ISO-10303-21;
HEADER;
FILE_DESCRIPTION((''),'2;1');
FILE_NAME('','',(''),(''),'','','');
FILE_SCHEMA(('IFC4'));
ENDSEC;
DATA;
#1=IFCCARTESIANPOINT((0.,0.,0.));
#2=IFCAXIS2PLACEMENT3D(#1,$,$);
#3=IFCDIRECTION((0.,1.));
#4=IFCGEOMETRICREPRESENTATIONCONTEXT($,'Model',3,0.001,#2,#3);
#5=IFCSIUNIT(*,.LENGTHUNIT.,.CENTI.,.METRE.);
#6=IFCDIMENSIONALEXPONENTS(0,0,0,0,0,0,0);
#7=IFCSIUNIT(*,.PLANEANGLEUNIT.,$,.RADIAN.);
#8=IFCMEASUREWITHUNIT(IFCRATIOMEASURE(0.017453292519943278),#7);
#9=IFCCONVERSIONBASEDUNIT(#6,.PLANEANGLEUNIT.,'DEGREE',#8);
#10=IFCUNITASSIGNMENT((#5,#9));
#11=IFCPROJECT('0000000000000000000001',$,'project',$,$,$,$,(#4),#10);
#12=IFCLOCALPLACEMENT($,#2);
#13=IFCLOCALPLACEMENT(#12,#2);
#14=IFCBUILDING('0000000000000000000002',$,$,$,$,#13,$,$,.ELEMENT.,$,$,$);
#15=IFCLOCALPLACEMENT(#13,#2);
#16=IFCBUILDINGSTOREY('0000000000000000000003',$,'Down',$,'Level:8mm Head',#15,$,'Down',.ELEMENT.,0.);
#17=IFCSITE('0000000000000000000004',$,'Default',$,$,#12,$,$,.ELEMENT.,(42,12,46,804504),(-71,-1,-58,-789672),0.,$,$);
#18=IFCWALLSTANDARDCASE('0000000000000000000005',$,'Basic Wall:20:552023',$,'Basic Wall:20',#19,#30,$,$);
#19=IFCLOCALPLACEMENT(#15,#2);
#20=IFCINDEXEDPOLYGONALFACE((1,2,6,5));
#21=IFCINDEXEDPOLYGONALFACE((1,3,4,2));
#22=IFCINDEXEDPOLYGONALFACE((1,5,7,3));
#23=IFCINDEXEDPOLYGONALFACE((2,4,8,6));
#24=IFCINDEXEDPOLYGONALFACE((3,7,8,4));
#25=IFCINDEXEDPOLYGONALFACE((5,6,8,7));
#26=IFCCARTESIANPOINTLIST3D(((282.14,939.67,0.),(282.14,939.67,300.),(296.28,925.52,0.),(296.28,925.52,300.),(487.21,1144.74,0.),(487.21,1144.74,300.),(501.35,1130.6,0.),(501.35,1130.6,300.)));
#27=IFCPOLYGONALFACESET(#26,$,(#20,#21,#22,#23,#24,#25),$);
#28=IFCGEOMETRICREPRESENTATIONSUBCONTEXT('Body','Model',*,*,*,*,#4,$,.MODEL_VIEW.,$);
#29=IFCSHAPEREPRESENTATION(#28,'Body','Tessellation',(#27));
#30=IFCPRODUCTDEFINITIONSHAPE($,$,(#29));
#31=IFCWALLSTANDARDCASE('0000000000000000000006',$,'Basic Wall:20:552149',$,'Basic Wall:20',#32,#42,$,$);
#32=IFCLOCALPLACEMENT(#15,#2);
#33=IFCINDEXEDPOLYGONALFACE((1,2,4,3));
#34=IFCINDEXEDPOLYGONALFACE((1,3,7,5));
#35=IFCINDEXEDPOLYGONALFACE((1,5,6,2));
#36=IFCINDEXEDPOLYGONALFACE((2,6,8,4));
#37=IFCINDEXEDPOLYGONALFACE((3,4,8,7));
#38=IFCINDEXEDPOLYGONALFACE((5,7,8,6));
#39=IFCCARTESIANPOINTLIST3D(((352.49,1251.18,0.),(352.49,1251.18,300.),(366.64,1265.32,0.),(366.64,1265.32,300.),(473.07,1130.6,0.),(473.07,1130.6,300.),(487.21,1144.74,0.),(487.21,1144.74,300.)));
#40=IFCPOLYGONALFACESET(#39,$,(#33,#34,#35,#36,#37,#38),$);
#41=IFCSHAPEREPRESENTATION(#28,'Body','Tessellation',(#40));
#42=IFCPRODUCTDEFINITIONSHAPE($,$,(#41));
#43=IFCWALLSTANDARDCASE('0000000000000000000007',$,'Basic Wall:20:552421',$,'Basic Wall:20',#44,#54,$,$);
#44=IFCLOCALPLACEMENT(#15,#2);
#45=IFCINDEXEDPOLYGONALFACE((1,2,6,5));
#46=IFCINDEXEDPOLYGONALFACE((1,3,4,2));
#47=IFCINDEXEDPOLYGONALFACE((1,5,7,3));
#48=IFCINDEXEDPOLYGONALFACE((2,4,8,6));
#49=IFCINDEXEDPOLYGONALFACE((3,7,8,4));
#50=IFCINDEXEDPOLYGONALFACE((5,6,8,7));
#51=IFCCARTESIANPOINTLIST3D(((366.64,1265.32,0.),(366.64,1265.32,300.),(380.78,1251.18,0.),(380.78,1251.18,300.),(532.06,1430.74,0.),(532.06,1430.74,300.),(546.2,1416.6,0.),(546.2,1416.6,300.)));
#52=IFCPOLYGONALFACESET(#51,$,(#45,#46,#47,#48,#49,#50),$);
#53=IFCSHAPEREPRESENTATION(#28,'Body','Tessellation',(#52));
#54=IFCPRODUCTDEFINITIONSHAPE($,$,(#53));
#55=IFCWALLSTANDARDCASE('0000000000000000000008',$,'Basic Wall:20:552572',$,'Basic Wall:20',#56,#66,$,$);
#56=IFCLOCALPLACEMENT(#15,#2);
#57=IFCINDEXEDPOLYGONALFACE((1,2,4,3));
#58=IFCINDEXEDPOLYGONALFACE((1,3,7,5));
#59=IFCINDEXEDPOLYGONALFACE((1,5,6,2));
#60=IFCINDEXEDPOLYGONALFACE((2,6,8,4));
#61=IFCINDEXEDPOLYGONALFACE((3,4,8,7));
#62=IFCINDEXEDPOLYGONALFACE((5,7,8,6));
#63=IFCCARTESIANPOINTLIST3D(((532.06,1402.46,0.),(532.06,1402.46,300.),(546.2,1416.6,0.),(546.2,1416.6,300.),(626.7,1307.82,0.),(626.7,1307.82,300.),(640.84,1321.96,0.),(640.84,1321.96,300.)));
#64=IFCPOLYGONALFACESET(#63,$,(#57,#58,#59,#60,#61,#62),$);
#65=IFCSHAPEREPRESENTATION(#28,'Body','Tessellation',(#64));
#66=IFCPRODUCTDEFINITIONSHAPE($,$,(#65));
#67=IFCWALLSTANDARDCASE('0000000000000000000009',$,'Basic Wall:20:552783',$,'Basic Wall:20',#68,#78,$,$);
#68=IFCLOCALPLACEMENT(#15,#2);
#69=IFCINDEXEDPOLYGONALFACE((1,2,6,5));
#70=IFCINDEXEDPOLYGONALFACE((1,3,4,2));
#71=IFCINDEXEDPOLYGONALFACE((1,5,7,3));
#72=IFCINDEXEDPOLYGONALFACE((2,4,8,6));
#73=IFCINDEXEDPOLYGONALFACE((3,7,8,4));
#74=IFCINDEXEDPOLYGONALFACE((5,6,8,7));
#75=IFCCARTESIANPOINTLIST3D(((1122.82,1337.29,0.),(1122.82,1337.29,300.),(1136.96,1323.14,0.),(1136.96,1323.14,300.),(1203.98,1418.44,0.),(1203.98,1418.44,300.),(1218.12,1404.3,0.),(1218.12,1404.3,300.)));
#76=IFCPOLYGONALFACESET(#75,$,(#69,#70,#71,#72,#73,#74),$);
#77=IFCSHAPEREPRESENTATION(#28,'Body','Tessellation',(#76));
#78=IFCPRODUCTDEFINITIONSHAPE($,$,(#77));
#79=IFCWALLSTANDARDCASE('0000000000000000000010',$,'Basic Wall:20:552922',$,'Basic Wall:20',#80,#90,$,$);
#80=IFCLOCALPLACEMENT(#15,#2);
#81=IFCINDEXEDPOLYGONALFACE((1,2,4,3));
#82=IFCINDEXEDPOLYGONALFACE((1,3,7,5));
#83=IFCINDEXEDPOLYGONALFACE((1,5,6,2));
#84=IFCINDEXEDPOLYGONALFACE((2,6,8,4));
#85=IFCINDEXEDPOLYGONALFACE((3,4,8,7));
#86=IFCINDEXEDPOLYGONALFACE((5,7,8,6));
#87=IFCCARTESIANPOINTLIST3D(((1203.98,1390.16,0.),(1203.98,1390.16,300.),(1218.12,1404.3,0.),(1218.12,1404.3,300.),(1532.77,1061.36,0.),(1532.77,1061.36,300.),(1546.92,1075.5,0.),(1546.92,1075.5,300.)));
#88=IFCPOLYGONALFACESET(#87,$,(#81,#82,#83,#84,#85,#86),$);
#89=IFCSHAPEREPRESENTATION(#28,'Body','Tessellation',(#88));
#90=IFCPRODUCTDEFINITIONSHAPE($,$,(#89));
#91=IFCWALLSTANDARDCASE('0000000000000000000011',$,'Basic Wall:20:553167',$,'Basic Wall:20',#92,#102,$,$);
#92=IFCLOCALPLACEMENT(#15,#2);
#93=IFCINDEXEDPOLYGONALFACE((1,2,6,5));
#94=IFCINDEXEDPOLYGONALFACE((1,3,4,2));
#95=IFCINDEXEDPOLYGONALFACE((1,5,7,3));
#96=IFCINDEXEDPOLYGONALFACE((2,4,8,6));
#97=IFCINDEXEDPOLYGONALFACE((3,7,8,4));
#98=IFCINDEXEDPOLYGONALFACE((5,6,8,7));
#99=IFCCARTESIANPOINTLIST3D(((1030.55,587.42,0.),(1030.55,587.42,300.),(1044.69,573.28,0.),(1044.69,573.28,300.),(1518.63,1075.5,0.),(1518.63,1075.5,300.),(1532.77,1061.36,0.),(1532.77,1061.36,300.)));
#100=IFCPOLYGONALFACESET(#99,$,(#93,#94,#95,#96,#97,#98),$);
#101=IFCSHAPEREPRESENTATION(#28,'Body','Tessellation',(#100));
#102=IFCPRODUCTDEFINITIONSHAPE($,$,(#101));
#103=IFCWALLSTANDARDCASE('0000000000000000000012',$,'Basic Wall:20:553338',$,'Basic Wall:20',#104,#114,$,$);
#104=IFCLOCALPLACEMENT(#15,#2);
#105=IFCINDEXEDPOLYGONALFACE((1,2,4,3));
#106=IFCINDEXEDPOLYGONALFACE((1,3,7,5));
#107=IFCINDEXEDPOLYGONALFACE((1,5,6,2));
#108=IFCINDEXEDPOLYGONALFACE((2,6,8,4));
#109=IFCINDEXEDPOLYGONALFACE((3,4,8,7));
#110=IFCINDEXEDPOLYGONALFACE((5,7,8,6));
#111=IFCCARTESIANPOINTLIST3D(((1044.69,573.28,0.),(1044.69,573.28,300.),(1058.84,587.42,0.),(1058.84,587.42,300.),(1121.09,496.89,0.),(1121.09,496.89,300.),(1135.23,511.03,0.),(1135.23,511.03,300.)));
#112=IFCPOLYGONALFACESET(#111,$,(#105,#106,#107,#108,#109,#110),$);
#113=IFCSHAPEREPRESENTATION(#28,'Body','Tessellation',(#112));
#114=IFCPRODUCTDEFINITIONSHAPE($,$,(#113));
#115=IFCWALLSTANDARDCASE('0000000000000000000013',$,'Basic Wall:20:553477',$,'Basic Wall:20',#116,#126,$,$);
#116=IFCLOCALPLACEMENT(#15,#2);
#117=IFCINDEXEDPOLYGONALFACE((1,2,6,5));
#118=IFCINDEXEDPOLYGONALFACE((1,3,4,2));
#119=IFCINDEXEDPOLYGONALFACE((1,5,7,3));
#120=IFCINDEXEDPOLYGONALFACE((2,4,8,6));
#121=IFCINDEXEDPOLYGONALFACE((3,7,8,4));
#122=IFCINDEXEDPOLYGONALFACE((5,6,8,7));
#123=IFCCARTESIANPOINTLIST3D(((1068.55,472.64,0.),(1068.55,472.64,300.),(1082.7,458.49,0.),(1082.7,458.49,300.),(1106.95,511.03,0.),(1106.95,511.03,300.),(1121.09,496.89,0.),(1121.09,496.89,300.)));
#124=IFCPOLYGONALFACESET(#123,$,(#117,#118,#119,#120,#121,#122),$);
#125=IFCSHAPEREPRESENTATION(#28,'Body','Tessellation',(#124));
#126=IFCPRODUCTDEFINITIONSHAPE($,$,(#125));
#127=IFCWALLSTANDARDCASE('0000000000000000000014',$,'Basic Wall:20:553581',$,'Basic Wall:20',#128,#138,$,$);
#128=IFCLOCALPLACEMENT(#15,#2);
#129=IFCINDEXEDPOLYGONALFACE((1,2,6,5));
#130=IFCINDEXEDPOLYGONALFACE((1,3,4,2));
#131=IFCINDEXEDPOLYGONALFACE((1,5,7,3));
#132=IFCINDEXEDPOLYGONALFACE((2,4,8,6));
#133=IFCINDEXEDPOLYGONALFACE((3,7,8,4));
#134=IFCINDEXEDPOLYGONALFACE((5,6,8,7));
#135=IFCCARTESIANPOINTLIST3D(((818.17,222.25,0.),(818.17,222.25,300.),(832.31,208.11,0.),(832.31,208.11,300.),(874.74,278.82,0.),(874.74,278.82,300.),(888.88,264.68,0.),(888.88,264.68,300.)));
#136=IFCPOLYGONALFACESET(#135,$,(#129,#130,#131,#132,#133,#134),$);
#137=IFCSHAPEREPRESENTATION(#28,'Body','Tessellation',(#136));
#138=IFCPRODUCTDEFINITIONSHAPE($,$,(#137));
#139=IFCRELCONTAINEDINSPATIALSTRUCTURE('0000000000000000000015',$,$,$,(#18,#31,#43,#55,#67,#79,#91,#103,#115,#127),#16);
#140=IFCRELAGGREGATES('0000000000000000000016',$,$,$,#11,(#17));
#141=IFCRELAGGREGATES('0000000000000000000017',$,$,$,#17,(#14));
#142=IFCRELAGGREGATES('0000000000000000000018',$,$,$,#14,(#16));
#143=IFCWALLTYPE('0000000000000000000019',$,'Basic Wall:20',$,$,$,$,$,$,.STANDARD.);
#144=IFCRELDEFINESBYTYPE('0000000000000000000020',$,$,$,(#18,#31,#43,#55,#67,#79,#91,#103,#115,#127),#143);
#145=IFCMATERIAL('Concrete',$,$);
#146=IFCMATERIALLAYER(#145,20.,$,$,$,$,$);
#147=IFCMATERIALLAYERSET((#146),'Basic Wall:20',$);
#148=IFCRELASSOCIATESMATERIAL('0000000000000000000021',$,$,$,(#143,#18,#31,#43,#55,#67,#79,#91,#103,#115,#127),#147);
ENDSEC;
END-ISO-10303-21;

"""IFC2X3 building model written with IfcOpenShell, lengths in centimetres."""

from ifc_helpers import new_model, entity, si_unit, converted_unit, direction, frame, frame_2d, origin, place, context, subcontext, project, spatial, rectangle, extrude, material, layer, layer_set, layer_usage, type_object, element, save


model = new_model("IFC2X3")

# Units and contexts
model_context = context("Model", 3, precision=0.001, world=origin(), true_north=direction((0.0, 1.0)))
body_context = subcontext(model_context, "Body", "Model", "MODEL_VIEW")
ifc_project = project(units=[si_unit("LENGTHUNIT", "METRE", prefix="CENTI"), converted_unit("PLANEANGLEUNIT", "DEGREE", entity("IfcRatioMeasure", 0.017453292519943278), si_unit("PLANEANGLEUNIT", "RADIAN"), dimensions=[0, 0, 0, 0, 0, 0, 0])], contexts=[model_context])

# Site, building, storey
site_placement = place(None, origin())
site = spatial("IfcSite", under=ifc_project, at=site_placement, Name="Default", CompositionType="ELEMENT", RefLatitude=(42, 12, 46, 804504), RefLongitude=(-71, -1, -58, -789672), RefElevation=0.0)
building_placement = place(site_placement, origin())
building = spatial("IfcBuilding", under=site, at=building_placement, CompositionType="ELEMENT")
storey_placement = place(building_placement, origin())
storey = spatial("IfcBuildingStorey", under=building, at=storey_placement, Name="Down", ObjectType="Level:8mm Head", LongName="Down", CompositionType="ELEMENT", Elevation=0.0)

# Walls
ifc_material = material(Name="Concrete")
ifc_layer_1 = layer(ifc_material, 20.0)
ifc_layer_set_1 = layer_set([ifc_layer_1], Name="Basic Wall:20")
wall_type_1 = type_object("IfcWallType", Name="Basic Wall:20", PredefinedType="STANDARD", material=ifc_layer_set_1)
ifc_layer_usage_1 = layer_usage(ifc_layer_set_1, "AXIS2", "NEGATIVE", 10.0)
wall_1_placement = place(storey_placement, frame((289.21, 932.6, 0.0), z_axis=(0.0, 0.0, 1.0), x_axis=(0.707107, 0.707107, 0.0)))
element("IfcWallStandardCase", 1, at=wall_1_placement, inside=storey, type_object=wall_type_1, material=ifc_layer_usage_1, Name="Basic Wall:20:552023", ObjectType="Basic Wall:20", context=body_context, shape_type="SweptSolid", body=[
    extrude(rectangle(XDim=290.02, YDim=20.0, at=frame_2d((145.01, 0.0), x_axis=(-1.0, 0.0))), origin(), (0.0, 0.0, 1.0), 300.0),
])
ifc_layer_usage_2 = layer_usage(ifc_layer_set_1, "AXIS2", "POSITIVE", -10.0)
wall_2_placement = place(storey_placement, frame((480.14, 1137.67, 0.0), z_axis=(0.0, 0.0, 1.0), x_axis=(-0.707107, 0.707107, 0.0)))
element("IfcWallStandardCase", 2, at=wall_2_placement, inside=storey, type_object=wall_type_1, material=ifc_layer_usage_2, Name="Basic Wall:20:552149", ObjectType="Basic Wall:20", context=body_context, shape_type="SweptSolid", body=[
    extrude(rectangle(XDim=170.52, YDim=20.0, at=frame_2d((85.26, 0.0), x_axis=(-1.0, 0.0))), origin(), (0.0, 0.0, 1.0), 300.0),
])
ifc_layer_usage_3 = layer_usage(ifc_layer_set_1, "AXIS2", "NEGATIVE", 10.0)
wall_3_placement = place(storey_placement, frame((373.71, 1258.25, 0.0), z_axis=(0.0, 0.0, 1.0), x_axis=(0.707107, 0.707107, 0.0)))
element("IfcWallStandardCase", 3, at=wall_3_placement, inside=storey, type_object=wall_type_1, material=ifc_layer_usage_3, Name="Basic Wall:20:552421", ObjectType="Basic Wall:20", context=body_context, shape_type="SweptSolid", body=[
    extrude(rectangle(XDim=233.94, YDim=20.0, at=frame_2d((116.97, 0.0), x_axis=(-1.0, 0.0))), origin(), (0.0, 0.0, 1.0), 300.0),
])
ifc_layer_usage_4 = layer_usage(ifc_layer_set_1, "AXIS2", "NEGATIVE", 10.0)
wall_4_placement = place(storey_placement, frame((539.13, 1409.53, 0.0), z_axis=(0.0, 0.0, 1.0), x_axis=(0.707107, -0.707107, 0.0)))
element("IfcWallStandardCase", 4, at=wall_4_placement, inside=storey, type_object=wall_type_1, material=ifc_layer_usage_4, Name="Basic Wall:20:552572", ObjectType="Basic Wall:20", context=body_context, shape_type="SweptSolid", body=[
    extrude(rectangle(XDim=133.84, YDim=20.0, at=frame_2d((66.92, 0.0), x_axis=(-1.0, 0.0))), origin(), (0.0, 0.0, 1.0), 300.0),
])
ifc_layer_usage_5 = layer_usage(ifc_layer_set_1, "AXIS2", "NEGATIVE", 10.0)
wall_5_placement = place(storey_placement, frame((1129.89, 1330.22, 0.0), z_axis=(0.0, 0.0, 1.0), x_axis=(0.707107, 0.707107, 0.0)))
element("IfcWallStandardCase", 5, at=wall_5_placement, inside=storey, type_object=wall_type_1, material=ifc_layer_usage_5, Name="Basic Wall:20:552783", ObjectType="Basic Wall:20", context=body_context, shape_type="SweptSolid", body=[
    extrude(rectangle(XDim=114.77, YDim=20.0, at=frame_2d((57.38, 0.0), x_axis=(-1.0, 0.0))), origin(), (0.0, 0.0, 1.0), 300.0),
])
ifc_layer_usage_6 = layer_usage(ifc_layer_set_1, "AXIS2", "NEGATIVE", 10.0)
wall_6_placement = place(storey_placement, frame((1211.05, 1397.23, 0.0), z_axis=(0.0, 0.0, 1.0), x_axis=(0.707107, -0.707107, 0.0)))
element("IfcWallStandardCase", 6, at=wall_6_placement, inside=storey, type_object=wall_type_1, material=ifc_layer_usage_6, Name="Basic Wall:20:552922", ObjectType="Basic Wall:20", context=body_context, shape_type="SweptSolid", body=[
    extrude(rectangle(XDim=464.99, YDim=20.0, at=frame_2d((232.49, 0.0), x_axis=(-1.0, 0.0))), origin(), (0.0, 0.0, 1.0), 300.0),
])
ifc_layer_usage_7 = layer_usage(ifc_layer_set_1, "AXIS2", "NEGATIVE", 10.0)
wall_7_placement = place(storey_placement, frame((1525.7, 1068.43, 0.0), z_axis=(0.0, 0.0, 1.0), x_axis=(-0.707107, -0.707107, 0.0)))
element("IfcWallStandardCase", 7, at=wall_7_placement, inside=storey, type_object=wall_type_1, material=ifc_layer_usage_7, Name="Basic Wall:20:553167", ObjectType="Basic Wall:20", context=body_context, shape_type="SweptSolid", body=[
    extrude(rectangle(XDim=690.25, YDim=20.0, at=frame_2d((345.12, 0.0), x_axis=(-1.0, 0.0))), origin(), (0.0, 0.0, 1.0), 300.0),
])
ifc_layer_usage_8 = layer_usage(ifc_layer_set_1, "AXIS2", "NEGATIVE", 10.0)
wall_8_placement = place(storey_placement, frame((1051.77, 580.35, 0.0), z_axis=(0.0, 0.0, 1.0), x_axis=(0.707107, -0.707107, 0.0)))
element("IfcWallStandardCase", 8, at=wall_8_placement, inside=storey, type_object=wall_type_1, material=ifc_layer_usage_8, Name="Basic Wall:20:553338", ObjectType="Basic Wall:20", context=body_context, shape_type="SweptSolid", body=[
    extrude(rectangle(XDim=108.04, YDim=20.0, at=frame_2d((54.02, 0.0), x_axis=(-1.0, 0.0))), origin(), (0.0, 0.0, 1.0), 300.0),
])
ifc_layer_usage_9 = layer_usage(ifc_layer_set_1, "AXIS2", "NEGATIVE", 10.0)
wall_9_placement = place(storey_placement, frame((1114.02, 503.96, 0.0), z_axis=(0.0, 0.0, 1.0), x_axis=(-0.707107, -0.707107, 0.0)))
element("IfcWallStandardCase", 9, at=wall_9_placement, inside=storey, type_object=wall_type_1, material=ifc_layer_usage_9, Name="Basic Wall:20:553477", ObjectType="Basic Wall:20", context=body_context, shape_type="SweptSolid", body=[
    extrude(rectangle(XDim=54.29, YDim=20.0, at=frame_2d((27.15, 0.0), x_axis=(-1.0, 0.0))), origin(), (0.0, 0.0, 1.0), 300.0),
])
ifc_layer_usage_10 = layer_usage(ifc_layer_set_1, "AXIS2", "NEGATIVE", 10.0)
wall_10_placement = place(storey_placement, frame((881.81, 271.75, 0.0), z_axis=(0.0, 0.0, 1.0), x_axis=(-0.707107, -0.707107, 0.0)))
element("IfcWallStandardCase", 10, at=wall_10_placement, inside=storey, type_object=wall_type_1, material=ifc_layer_usage_10, Name="Basic Wall:20:553581", ObjectType="Basic Wall:20", context=body_context, shape_type="SweptSolid", body=[
    extrude(rectangle(XDim=80.0, YDim=20.0, at=frame_2d((40.0, 0.0), x_axis=(-1.0, 0.0))), origin(), (0.0, 0.0, 1.0), 300.0),
])

save(model, "model.ifc")
